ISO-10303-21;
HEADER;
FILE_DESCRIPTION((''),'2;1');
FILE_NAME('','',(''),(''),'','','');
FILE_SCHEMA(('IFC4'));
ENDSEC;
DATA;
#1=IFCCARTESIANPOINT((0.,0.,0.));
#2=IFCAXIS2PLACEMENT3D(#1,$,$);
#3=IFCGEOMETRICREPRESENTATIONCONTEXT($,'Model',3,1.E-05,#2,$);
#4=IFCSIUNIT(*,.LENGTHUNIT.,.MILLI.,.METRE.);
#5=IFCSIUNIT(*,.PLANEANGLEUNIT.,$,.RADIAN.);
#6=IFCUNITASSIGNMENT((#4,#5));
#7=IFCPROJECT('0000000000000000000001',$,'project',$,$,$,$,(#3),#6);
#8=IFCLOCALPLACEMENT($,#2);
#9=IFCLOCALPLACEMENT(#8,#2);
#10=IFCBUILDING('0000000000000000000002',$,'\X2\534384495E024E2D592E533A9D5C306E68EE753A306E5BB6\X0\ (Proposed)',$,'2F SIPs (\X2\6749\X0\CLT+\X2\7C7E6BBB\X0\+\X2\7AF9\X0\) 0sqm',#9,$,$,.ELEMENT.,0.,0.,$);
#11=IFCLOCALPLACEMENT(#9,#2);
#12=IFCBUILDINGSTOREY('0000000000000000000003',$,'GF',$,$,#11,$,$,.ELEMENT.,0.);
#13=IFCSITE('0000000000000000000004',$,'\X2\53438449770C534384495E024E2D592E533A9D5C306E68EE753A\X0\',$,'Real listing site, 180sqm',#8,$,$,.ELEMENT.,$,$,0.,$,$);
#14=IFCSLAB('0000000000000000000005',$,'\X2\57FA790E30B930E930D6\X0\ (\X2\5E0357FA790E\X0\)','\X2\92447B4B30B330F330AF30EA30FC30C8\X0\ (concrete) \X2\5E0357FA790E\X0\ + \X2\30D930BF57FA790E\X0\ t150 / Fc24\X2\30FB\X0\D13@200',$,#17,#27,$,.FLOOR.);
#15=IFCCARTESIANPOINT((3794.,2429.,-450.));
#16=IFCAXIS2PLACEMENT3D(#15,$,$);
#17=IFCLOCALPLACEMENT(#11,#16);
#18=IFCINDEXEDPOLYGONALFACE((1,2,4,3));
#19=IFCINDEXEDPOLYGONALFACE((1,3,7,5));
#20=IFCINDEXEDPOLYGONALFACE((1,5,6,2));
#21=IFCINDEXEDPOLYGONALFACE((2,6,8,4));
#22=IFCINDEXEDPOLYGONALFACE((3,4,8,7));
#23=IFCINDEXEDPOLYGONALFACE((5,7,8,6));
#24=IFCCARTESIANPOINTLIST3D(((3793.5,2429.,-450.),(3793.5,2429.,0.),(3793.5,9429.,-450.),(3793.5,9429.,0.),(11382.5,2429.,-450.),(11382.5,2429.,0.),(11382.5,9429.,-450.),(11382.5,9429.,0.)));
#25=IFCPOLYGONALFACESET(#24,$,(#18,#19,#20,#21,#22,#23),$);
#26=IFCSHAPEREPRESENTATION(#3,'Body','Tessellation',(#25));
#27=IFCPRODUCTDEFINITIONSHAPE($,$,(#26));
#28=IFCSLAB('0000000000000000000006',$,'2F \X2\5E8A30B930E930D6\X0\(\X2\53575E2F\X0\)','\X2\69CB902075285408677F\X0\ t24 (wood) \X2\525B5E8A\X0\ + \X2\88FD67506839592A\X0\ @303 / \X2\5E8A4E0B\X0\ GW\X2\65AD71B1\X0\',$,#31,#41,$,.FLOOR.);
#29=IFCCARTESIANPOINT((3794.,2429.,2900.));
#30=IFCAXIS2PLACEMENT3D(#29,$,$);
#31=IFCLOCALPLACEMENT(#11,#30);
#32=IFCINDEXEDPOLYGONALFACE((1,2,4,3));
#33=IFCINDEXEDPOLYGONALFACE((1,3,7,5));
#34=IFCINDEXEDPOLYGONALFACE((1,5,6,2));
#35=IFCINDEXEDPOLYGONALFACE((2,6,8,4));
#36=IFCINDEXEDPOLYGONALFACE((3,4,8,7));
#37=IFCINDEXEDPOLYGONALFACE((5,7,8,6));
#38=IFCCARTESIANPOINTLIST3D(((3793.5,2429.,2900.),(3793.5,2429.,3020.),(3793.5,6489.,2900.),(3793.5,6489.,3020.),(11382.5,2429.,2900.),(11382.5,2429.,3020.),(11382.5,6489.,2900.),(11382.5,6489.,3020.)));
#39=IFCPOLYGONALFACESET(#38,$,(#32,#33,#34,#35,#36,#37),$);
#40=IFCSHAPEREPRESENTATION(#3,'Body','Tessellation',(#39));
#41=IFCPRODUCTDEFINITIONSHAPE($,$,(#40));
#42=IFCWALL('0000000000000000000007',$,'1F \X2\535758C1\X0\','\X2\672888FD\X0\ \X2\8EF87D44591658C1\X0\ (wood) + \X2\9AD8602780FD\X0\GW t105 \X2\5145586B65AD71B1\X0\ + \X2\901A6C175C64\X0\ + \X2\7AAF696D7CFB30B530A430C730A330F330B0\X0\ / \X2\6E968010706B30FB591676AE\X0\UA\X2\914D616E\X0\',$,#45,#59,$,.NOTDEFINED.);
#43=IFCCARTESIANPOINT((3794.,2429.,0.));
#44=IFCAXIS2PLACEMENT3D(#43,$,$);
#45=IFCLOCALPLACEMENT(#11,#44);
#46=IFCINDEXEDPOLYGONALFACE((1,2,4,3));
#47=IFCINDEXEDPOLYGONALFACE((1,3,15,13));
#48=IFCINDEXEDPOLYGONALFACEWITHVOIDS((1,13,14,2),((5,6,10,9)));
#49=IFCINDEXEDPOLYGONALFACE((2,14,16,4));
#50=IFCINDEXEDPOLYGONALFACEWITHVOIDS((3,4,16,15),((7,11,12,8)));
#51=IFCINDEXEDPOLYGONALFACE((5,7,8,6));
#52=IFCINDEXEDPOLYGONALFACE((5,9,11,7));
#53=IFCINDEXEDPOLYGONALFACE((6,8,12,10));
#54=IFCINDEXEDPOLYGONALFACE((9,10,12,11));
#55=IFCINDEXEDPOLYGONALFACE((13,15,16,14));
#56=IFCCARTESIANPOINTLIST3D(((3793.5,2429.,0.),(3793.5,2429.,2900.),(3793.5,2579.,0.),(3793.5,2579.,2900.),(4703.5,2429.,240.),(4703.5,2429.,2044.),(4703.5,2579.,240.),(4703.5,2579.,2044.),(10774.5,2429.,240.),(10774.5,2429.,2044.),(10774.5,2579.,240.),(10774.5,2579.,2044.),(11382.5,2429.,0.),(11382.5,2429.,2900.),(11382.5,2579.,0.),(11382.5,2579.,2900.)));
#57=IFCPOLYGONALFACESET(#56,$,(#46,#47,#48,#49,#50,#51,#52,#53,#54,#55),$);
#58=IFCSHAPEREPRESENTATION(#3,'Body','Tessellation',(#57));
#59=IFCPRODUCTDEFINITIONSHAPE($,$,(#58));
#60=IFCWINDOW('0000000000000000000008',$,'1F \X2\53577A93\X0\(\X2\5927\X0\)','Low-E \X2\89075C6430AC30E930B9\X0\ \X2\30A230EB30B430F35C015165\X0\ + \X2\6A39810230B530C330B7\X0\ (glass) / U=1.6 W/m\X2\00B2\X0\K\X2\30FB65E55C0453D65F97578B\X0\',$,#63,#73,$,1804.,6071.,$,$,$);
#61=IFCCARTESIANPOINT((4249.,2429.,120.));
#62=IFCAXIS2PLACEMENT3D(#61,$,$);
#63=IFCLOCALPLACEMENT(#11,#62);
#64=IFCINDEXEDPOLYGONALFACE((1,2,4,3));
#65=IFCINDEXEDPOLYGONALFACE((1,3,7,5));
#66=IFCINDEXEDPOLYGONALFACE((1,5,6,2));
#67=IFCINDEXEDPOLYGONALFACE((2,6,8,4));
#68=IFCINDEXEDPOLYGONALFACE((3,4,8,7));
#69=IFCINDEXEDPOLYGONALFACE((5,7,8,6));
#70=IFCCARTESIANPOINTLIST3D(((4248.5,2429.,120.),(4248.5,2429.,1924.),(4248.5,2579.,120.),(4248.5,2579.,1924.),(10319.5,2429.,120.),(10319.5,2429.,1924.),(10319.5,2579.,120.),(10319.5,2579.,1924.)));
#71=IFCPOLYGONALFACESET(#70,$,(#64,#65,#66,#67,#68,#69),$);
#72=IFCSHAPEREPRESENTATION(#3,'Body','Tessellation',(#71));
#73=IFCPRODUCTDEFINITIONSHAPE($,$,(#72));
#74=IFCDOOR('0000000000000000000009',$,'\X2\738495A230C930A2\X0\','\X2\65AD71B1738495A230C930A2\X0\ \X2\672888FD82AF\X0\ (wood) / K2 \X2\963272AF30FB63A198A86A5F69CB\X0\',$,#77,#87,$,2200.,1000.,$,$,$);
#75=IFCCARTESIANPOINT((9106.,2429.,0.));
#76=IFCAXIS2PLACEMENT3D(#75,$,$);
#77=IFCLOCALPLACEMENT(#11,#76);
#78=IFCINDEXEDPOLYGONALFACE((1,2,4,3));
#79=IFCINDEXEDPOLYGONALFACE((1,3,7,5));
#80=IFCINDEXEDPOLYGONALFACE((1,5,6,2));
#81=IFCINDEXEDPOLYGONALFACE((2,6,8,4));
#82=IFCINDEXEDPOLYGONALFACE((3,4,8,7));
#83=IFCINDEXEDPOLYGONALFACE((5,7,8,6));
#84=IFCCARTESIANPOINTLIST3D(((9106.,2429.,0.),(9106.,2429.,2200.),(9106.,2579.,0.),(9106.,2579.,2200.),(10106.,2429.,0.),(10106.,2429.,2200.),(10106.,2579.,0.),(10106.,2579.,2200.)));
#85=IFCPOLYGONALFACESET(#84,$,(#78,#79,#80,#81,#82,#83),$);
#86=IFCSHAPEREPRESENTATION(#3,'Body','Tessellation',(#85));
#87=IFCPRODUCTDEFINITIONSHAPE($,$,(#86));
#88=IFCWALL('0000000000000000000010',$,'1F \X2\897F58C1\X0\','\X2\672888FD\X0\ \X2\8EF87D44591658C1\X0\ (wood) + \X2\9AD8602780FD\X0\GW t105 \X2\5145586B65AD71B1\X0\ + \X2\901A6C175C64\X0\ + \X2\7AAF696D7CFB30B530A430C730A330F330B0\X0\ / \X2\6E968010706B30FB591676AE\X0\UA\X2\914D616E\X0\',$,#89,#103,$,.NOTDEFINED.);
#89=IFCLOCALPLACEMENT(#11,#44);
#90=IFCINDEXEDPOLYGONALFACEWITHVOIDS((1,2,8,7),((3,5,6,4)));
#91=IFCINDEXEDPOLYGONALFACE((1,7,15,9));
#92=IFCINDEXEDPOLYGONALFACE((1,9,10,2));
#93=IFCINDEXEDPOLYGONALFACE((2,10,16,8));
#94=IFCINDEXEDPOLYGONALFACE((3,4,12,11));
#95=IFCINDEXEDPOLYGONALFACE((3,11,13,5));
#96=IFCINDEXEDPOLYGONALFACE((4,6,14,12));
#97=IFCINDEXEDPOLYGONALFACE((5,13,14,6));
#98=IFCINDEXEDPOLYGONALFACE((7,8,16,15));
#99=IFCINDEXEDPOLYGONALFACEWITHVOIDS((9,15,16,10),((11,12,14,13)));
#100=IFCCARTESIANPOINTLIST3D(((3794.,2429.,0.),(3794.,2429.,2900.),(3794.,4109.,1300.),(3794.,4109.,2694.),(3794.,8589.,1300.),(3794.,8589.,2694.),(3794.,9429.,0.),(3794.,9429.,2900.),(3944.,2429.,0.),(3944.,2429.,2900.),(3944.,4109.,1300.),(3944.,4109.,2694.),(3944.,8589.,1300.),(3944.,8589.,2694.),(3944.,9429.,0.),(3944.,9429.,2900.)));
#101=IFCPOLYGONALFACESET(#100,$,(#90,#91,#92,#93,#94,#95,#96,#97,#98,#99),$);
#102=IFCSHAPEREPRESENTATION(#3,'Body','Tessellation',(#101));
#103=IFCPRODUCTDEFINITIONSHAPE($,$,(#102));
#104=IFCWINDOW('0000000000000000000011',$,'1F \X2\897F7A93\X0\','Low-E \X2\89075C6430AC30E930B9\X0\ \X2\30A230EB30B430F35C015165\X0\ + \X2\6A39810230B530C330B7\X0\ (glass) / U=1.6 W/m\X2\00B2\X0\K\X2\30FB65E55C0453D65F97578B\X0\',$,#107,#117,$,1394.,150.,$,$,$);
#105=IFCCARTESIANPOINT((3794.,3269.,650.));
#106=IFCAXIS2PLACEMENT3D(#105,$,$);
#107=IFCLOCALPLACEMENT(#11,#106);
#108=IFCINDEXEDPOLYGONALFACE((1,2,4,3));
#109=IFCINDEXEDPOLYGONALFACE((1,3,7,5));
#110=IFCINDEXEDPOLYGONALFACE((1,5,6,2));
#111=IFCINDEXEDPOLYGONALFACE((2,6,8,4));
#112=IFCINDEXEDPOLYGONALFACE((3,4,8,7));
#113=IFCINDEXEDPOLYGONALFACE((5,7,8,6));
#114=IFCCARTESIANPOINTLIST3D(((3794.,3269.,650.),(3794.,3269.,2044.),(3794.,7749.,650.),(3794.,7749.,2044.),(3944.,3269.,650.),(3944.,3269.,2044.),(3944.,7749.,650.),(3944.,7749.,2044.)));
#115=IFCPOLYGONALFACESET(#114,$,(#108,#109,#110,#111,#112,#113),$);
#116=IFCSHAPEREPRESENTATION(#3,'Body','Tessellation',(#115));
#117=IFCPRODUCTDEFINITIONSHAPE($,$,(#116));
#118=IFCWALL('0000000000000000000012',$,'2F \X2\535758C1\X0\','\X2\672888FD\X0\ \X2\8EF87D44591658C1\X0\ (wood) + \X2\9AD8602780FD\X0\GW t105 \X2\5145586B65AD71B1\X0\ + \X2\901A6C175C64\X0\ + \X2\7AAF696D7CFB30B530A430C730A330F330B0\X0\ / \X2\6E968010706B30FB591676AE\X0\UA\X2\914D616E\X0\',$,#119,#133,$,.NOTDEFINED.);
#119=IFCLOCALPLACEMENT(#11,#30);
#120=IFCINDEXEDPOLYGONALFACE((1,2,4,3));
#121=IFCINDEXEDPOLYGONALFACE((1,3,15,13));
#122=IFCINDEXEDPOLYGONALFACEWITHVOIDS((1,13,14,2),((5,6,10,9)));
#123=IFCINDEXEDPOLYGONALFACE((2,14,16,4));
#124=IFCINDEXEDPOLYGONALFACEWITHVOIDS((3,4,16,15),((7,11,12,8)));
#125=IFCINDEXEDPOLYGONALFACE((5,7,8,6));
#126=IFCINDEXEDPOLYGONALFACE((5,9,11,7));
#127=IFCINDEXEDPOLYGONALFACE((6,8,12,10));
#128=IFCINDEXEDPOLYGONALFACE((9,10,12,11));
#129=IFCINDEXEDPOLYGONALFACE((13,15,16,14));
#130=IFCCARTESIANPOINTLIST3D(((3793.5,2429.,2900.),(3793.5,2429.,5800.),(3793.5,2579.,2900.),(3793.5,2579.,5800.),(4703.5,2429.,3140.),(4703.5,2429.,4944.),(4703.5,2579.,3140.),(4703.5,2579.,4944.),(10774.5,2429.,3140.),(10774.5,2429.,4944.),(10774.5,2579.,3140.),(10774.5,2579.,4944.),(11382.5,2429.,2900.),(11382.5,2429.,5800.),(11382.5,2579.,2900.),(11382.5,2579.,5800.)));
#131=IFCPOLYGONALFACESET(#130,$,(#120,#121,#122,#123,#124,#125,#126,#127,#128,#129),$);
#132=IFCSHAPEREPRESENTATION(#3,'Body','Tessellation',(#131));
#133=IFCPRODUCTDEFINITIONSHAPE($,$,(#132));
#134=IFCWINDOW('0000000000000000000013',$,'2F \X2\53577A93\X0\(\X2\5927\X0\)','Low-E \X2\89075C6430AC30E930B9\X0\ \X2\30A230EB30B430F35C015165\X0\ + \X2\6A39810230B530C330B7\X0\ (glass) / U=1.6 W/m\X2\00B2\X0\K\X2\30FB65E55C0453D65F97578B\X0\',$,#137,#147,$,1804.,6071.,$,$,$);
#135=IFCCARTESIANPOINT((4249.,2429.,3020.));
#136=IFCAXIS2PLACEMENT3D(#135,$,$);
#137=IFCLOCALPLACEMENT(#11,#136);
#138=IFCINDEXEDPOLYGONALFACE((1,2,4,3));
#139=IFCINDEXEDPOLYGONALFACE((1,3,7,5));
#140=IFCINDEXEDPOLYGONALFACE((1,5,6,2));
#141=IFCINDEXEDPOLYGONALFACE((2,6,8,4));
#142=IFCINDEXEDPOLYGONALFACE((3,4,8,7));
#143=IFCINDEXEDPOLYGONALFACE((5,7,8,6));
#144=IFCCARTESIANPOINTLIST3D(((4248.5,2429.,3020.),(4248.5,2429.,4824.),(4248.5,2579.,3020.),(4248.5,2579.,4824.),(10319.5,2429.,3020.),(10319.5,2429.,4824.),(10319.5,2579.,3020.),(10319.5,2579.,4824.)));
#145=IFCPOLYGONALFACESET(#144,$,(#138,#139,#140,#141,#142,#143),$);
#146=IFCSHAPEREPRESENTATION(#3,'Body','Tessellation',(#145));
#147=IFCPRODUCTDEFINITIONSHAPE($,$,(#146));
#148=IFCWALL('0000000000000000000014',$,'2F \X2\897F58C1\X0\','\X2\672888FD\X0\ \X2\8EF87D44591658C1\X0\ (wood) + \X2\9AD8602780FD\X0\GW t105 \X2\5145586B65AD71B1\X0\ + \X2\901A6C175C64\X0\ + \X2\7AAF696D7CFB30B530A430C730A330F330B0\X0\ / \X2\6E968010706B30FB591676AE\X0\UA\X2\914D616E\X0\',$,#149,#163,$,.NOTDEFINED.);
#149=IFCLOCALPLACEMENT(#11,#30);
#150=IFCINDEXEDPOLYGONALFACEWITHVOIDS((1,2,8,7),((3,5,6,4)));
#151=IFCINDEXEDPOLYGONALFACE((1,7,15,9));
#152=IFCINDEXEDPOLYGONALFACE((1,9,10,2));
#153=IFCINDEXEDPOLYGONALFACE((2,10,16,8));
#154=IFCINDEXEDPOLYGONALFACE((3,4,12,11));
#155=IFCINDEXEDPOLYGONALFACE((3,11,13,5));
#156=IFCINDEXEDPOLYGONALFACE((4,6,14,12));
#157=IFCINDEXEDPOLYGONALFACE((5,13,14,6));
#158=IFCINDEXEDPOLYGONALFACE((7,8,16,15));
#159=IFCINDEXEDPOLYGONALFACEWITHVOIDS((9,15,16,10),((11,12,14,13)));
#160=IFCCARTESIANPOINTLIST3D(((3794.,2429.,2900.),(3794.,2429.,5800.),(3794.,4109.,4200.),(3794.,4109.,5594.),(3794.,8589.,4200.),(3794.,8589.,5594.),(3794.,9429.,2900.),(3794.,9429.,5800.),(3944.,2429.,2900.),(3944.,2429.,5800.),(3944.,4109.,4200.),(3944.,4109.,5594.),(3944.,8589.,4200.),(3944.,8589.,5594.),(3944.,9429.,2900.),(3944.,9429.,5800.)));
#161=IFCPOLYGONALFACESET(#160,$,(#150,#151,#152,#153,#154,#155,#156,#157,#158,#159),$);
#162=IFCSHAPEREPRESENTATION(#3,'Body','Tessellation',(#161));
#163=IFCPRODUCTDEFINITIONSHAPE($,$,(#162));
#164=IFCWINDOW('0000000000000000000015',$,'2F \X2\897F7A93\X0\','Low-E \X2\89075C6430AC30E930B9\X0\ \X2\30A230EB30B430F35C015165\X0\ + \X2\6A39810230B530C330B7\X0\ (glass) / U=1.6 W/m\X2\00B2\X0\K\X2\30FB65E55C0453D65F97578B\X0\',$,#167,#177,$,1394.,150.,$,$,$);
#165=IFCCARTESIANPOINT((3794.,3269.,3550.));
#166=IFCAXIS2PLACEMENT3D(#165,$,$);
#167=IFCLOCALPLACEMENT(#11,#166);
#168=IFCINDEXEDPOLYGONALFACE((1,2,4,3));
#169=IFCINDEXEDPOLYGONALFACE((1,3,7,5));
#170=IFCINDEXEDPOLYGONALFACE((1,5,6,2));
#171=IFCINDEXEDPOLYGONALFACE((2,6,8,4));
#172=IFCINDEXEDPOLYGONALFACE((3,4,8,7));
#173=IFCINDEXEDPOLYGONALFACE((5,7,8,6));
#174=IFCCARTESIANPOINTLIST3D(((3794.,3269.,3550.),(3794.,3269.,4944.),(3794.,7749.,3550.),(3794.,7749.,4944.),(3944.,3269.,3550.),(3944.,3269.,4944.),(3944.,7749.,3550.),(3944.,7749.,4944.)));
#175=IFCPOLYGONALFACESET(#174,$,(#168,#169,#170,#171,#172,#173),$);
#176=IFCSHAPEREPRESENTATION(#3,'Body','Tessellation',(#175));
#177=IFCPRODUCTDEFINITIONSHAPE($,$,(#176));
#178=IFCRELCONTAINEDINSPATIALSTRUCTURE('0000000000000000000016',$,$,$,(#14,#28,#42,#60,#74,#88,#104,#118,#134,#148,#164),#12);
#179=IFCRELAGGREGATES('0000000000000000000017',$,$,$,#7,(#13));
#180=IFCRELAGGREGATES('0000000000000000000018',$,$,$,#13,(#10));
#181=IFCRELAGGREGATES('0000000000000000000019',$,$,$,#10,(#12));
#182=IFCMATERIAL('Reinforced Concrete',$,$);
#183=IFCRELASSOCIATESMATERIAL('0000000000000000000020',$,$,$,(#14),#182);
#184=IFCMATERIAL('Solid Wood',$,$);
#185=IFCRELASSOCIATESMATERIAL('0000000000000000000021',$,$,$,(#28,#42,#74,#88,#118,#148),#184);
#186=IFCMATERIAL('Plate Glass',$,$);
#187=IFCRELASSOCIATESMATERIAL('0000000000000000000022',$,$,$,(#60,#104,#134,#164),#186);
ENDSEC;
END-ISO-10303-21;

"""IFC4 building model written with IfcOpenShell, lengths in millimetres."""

from ifc_helpers import new_model, si_unit, frame, frame_2d, origin, place, context, project, spatial, rectangle, extrude, material, element, fill, save


model = new_model("IFC4")

# Units and contexts
model_context = context("Model", 3, precision=1e-05, world=origin())
ifc_project = project(units=[si_unit("LENGTHUNIT", "METRE", prefix="MILLI"), si_unit("PLANEANGLEUNIT", "RADIAN")], contexts=[model_context])

# Site, building, storey
site_placement = place(None, origin())
site = spatial("IfcSite", under=ifc_project, at=site_placement, Name="千葉県千葉市中央区鵜の森町", ObjectType="Real listing site, 180sqm", CompositionType="ELEMENT", RefElevation=0.0)
building_placement = place(site_placement, origin())
building = spatial("IfcBuilding", under=site, at=building_placement, Name="千葉市中央区鵜の森町の家 (Proposed)", ObjectType="2F SIPs (杉CLT+籾殻+竹) 0sqm", CompositionType="ELEMENT", ElevationOfRefHeight=0.0, ElevationOfTerrain=0.0)
storey_placement = place(building_placement, origin())
storey = spatial("IfcBuildingStorey", under=building, at=storey_placement, Name="GF", CompositionType="ELEMENT", Elevation=0.0)

# Slabs
ifc_material_1 = material(Name="Reinforced Concrete")
slab_1_placement = place(storey_placement, frame((3794.0, 2429.0, -450.0)))
element("IfcSlab", 1, at=slab_1_placement, inside=storey, material=ifc_material_1, Name="基礎スラブ (布基礎)", Description="鉄筋コンクリート (concrete) 布基礎 + ベタ基礎 t150 / Fc24・D13@200", PredefinedType="FLOOR", context=model_context, shape_type="SweptSolid", body=[
    extrude(rectangle(XDim=7589.0, YDim=7000.0, at=frame_2d((3794.0, 3500.0))), frame((3794.0, 2429.0, -450.0)), (0.0, 0.0, 1.0), 450.0),
])
ifc_material_2 = material(Name="Solid Wood")
slab_2_placement = place(storey_placement, frame((3794.0, 2429.0, 2900.0)))
element("IfcSlab", 2, at=slab_2_placement, inside=storey, material=ifc_material_2, Name="2F 床スラブ(南帯)", Description="構造用合板 t24 (wood) 剛床 + 製材根太 @303 / 床下 GW断熱", PredefinedType="FLOOR", context=model_context, shape_type="SweptSolid", body=[
    extrude(rectangle(XDim=7589.0, YDim=4060.0, at=frame_2d((3794.0, 2030.0))), frame((3794.0, 2429.0, 2900.0)), (0.0, 0.0, 1.0), 120.0),
])

# Wall, openings, window, door
wall_1_placement = place(storey_placement, frame((3794.0, 2429.0, 0.0)))
wall_1 = element("IfcWall", 3, at=wall_1_placement, inside=storey, material=ifc_material_2, Name="1F 南壁", Description="木製 軸組外壁 (wood) + 高性能GW t105 充填断熱 + 通気層 + 窯業系サイディング / 準耐火・外皮UA配慮", PredefinedType="NOTDEFINED", context=model_context, shape_type="SweptSolid", body=[
    extrude(rectangle(XDim=7589.0, YDim=150.0, at=frame_2d((3794.0, 75.0))), frame((3794.0, 2429.0, 0.0)), (0.0, 0.0, 1.0), 2900.0),
])
opening_1_placement = place(storey_placement, frame((4249.0, 2429.0, 120.0)))
opening_1 = element("IfcOpeningElement", 4, at=opening_1_placement, cuts=wall_1, PredefinedType="NOTDEFINED", context=model_context, shape_type="SweptSolid", body=[
    extrude(rectangle(XDim=6071.0, YDim=150.0, at=frame_2d((3035.0, 75.0))), frame((4249.0, 2429.0, 120.0)), (0.0, 0.0, 1.0), 1804.0),
])
opening_2_placement = place(storey_placement, frame((9106.0, 2429.0, 0.0)))
opening_2 = element("IfcOpeningElement", 5, at=opening_2_placement, cuts=wall_1, PredefinedType="NOTDEFINED", context=model_context, shape_type="SweptSolid", body=[
    extrude(rectangle(XDim=1000.0, YDim=150.0, at=frame_2d((500.0, 75.0))), frame((9106.0, 2429.0, 0.0)), (0.0, 0.0, 1.0), 2200.0),
])
ifc_material_3 = material(Name="Plate Glass")
window_1_placement = place(storey_placement, frame((4249.0, 2429.0, 120.0)))
window_1 = element("IfcWindow", 6, at=window_1_placement, inside=storey, material=ifc_material_3, Name="1F 南窓(大)", Description="Low-E 複層ガラス アルゴン封入 + 樹脂サッシ (glass) / U=1.6 W/m²K・日射取得型", OverallHeight=1804.0, OverallWidth=6071.0, context=model_context, shape_type="SweptSolid", body=[
    extrude(rectangle(XDim=6071.0, YDim=150.0, at=frame_2d((3035.0, 75.0))), frame((4249.0, 2429.0, 120.0)), (0.0, 0.0, 1.0), 1804.0),
])
fill(opening_1, window_1)
door_placement = place(storey_placement, frame((9106.0, 2429.0, 0.0)))
door = element("IfcDoor", 7, at=door_placement, inside=storey, material=ifc_material_2, Name="玄関ドア", Description="断熱玄関ドア 木製芯 (wood) / K2 防犯・採風機構", OverallHeight=2200.0, OverallWidth=1000.0, context=model_context, shape_type="SweptSolid", body=[
    extrude(rectangle(XDim=1000.0, YDim=150.0, at=frame_2d((500.0, 75.0))), frame((9106.0, 2429.0, 0.0)), (0.0, 0.0, 1.0), 2200.0),
])
fill(opening_2, door)

# Wall, opening, window
wall_2_placement = place(storey_placement, frame((3794.0, 2429.0, 0.0)))
wall_2 = element("IfcWall", 8, at=wall_2_placement, inside=storey, material=ifc_material_2, Name="1F 西壁", Description="木製 軸組外壁 (wood) + 高性能GW t105 充填断熱 + 通気層 + 窯業系サイディング / 準耐火・外皮UA配慮", PredefinedType="NOTDEFINED", context=model_context, shape_type="SweptSolid", body=[
    extrude(rectangle(XDim=150.0, YDim=7000.0, at=frame_2d((75.0, 3500.0))), frame((3794.0, 2429.0, 0.0)), (0.0, 0.0, 1.0), 2900.0),
])
opening_3_placement = place(storey_placement, frame((3794.0, 3269.0, 650.0)))
opening_3 = element("IfcOpeningElement", 9, at=opening_3_placement, cuts=wall_2, PredefinedType="NOTDEFINED", context=model_context, shape_type="SweptSolid", body=[
    extrude(rectangle(XDim=150.0, YDim=4480.0, at=frame_2d((75.0, 2240.0))), frame((3794.0, 3269.0, 650.0)), (0.0, 0.0, 1.0), 1394.0),
])
window_2_placement = place(storey_placement, frame((3794.0, 3269.0, 650.0)))
window_2 = element("IfcWindow", 10, at=window_2_placement, inside=storey, material=ifc_material_3, Name="1F 西窓", Description="Low-E 複層ガラス アルゴン封入 + 樹脂サッシ (glass) / U=1.6 W/m²K・日射取得型", OverallHeight=1394.0, OverallWidth=150.0, context=model_context, shape_type="SweptSolid", body=[
    extrude(rectangle(XDim=150.0, YDim=4480.0, at=frame_2d((75.0, 2240.0))), frame((3794.0, 3269.0, 650.0)), (0.0, 0.0, 1.0), 1394.0),
])
fill(opening_3, window_2)

# Walls, openings, windows
wall_3_placement = place(storey_placement, frame((3794.0, 2429.0, 2900.0)))
wall_3 = element("IfcWall", 11, at=wall_3_placement, inside=storey, material=ifc_material_2, Name="2F 南壁", Description="木製 軸組外壁 (wood) + 高性能GW t105 充填断熱 + 通気層 + 窯業系サイディング / 準耐火・外皮UA配慮", PredefinedType="NOTDEFINED", context=model_context, shape_type="SweptSolid", body=[
    extrude(rectangle(XDim=7589.0, YDim=150.0, at=frame_2d((3794.0, 75.0))), frame((3794.0, 2429.0, 2900.0)), (0.0, 0.0, 1.0), 2900.0),
])
opening_4_placement = place(storey_placement, frame((4249.0, 2429.0, 3020.0)))
opening_4 = element("IfcOpeningElement", 12, at=opening_4_placement, cuts=wall_3, PredefinedType="NOTDEFINED", context=model_context, shape_type="SweptSolid", body=[
    extrude(rectangle(XDim=6071.0, YDim=150.0, at=frame_2d((3035.0, 75.0))), frame((4249.0, 2429.0, 3020.0)), (0.0, 0.0, 1.0), 1804.0),
])
window_3_placement = place(storey_placement, frame((4249.0, 2429.0, 3020.0)))
window_3 = element("IfcWindow", 13, at=window_3_placement, inside=storey, material=ifc_material_3, Name="2F 南窓(大)", Description="Low-E 複層ガラス アルゴン封入 + 樹脂サッシ (glass) / U=1.6 W/m²K・日射取得型", OverallHeight=1804.0, OverallWidth=6071.0, context=model_context, shape_type="SweptSolid", body=[
    extrude(rectangle(XDim=6071.0, YDim=150.0, at=frame_2d((3035.0, 75.0))), frame((4249.0, 2429.0, 3020.0)), (0.0, 0.0, 1.0), 1804.0),
])
fill(opening_4, window_3)
wall_4_placement = place(storey_placement, frame((3794.0, 2429.0, 2900.0)))
wall_4 = element("IfcWall", 14, at=wall_4_placement, inside=storey, material=ifc_material_2, Name="2F 西壁", Description="木製 軸組外壁 (wood) + 高性能GW t105 充填断熱 + 通気層 + 窯業系サイディング / 準耐火・外皮UA配慮", PredefinedType="NOTDEFINED", context=model_context, shape_type="SweptSolid", body=[
    extrude(rectangle(XDim=150.0, YDim=7000.0, at=frame_2d((75.0, 3500.0))), frame((3794.0, 2429.0, 2900.0)), (0.0, 0.0, 1.0), 2900.0),
])
opening_5_placement = place(storey_placement, frame((3794.0, 3269.0, 3550.0)))
opening_5 = element("IfcOpeningElement", 15, at=opening_5_placement, cuts=wall_4, PredefinedType="NOTDEFINED", context=model_context, shape_type="SweptSolid", body=[
    extrude(rectangle(XDim=150.0, YDim=4480.0, at=frame_2d((75.0, 2240.0))), frame((3794.0, 3269.0, 3550.0)), (0.0, 0.0, 1.0), 1394.0),
])
window_4_placement = place(storey_placement, frame((3794.0, 3269.0, 3550.0)))
window_4 = element("IfcWindow", 16, at=window_4_placement, inside=storey, material=ifc_material_3, Name="2F 西窓", Description="Low-E 複層ガラス アルゴン封入 + 樹脂サッシ (glass) / U=1.6 W/m²K・日射取得型", OverallHeight=1394.0, OverallWidth=150.0, context=model_context, shape_type="SweptSolid", body=[
    extrude(rectangle(XDim=150.0, YDim=4480.0, at=frame_2d((75.0, 2240.0))), frame((3794.0, 3269.0, 3550.0)), (0.0, 0.0, 1.0), 1394.0),
])
fill(opening_5, window_4)

save(model, "model.ifc")
